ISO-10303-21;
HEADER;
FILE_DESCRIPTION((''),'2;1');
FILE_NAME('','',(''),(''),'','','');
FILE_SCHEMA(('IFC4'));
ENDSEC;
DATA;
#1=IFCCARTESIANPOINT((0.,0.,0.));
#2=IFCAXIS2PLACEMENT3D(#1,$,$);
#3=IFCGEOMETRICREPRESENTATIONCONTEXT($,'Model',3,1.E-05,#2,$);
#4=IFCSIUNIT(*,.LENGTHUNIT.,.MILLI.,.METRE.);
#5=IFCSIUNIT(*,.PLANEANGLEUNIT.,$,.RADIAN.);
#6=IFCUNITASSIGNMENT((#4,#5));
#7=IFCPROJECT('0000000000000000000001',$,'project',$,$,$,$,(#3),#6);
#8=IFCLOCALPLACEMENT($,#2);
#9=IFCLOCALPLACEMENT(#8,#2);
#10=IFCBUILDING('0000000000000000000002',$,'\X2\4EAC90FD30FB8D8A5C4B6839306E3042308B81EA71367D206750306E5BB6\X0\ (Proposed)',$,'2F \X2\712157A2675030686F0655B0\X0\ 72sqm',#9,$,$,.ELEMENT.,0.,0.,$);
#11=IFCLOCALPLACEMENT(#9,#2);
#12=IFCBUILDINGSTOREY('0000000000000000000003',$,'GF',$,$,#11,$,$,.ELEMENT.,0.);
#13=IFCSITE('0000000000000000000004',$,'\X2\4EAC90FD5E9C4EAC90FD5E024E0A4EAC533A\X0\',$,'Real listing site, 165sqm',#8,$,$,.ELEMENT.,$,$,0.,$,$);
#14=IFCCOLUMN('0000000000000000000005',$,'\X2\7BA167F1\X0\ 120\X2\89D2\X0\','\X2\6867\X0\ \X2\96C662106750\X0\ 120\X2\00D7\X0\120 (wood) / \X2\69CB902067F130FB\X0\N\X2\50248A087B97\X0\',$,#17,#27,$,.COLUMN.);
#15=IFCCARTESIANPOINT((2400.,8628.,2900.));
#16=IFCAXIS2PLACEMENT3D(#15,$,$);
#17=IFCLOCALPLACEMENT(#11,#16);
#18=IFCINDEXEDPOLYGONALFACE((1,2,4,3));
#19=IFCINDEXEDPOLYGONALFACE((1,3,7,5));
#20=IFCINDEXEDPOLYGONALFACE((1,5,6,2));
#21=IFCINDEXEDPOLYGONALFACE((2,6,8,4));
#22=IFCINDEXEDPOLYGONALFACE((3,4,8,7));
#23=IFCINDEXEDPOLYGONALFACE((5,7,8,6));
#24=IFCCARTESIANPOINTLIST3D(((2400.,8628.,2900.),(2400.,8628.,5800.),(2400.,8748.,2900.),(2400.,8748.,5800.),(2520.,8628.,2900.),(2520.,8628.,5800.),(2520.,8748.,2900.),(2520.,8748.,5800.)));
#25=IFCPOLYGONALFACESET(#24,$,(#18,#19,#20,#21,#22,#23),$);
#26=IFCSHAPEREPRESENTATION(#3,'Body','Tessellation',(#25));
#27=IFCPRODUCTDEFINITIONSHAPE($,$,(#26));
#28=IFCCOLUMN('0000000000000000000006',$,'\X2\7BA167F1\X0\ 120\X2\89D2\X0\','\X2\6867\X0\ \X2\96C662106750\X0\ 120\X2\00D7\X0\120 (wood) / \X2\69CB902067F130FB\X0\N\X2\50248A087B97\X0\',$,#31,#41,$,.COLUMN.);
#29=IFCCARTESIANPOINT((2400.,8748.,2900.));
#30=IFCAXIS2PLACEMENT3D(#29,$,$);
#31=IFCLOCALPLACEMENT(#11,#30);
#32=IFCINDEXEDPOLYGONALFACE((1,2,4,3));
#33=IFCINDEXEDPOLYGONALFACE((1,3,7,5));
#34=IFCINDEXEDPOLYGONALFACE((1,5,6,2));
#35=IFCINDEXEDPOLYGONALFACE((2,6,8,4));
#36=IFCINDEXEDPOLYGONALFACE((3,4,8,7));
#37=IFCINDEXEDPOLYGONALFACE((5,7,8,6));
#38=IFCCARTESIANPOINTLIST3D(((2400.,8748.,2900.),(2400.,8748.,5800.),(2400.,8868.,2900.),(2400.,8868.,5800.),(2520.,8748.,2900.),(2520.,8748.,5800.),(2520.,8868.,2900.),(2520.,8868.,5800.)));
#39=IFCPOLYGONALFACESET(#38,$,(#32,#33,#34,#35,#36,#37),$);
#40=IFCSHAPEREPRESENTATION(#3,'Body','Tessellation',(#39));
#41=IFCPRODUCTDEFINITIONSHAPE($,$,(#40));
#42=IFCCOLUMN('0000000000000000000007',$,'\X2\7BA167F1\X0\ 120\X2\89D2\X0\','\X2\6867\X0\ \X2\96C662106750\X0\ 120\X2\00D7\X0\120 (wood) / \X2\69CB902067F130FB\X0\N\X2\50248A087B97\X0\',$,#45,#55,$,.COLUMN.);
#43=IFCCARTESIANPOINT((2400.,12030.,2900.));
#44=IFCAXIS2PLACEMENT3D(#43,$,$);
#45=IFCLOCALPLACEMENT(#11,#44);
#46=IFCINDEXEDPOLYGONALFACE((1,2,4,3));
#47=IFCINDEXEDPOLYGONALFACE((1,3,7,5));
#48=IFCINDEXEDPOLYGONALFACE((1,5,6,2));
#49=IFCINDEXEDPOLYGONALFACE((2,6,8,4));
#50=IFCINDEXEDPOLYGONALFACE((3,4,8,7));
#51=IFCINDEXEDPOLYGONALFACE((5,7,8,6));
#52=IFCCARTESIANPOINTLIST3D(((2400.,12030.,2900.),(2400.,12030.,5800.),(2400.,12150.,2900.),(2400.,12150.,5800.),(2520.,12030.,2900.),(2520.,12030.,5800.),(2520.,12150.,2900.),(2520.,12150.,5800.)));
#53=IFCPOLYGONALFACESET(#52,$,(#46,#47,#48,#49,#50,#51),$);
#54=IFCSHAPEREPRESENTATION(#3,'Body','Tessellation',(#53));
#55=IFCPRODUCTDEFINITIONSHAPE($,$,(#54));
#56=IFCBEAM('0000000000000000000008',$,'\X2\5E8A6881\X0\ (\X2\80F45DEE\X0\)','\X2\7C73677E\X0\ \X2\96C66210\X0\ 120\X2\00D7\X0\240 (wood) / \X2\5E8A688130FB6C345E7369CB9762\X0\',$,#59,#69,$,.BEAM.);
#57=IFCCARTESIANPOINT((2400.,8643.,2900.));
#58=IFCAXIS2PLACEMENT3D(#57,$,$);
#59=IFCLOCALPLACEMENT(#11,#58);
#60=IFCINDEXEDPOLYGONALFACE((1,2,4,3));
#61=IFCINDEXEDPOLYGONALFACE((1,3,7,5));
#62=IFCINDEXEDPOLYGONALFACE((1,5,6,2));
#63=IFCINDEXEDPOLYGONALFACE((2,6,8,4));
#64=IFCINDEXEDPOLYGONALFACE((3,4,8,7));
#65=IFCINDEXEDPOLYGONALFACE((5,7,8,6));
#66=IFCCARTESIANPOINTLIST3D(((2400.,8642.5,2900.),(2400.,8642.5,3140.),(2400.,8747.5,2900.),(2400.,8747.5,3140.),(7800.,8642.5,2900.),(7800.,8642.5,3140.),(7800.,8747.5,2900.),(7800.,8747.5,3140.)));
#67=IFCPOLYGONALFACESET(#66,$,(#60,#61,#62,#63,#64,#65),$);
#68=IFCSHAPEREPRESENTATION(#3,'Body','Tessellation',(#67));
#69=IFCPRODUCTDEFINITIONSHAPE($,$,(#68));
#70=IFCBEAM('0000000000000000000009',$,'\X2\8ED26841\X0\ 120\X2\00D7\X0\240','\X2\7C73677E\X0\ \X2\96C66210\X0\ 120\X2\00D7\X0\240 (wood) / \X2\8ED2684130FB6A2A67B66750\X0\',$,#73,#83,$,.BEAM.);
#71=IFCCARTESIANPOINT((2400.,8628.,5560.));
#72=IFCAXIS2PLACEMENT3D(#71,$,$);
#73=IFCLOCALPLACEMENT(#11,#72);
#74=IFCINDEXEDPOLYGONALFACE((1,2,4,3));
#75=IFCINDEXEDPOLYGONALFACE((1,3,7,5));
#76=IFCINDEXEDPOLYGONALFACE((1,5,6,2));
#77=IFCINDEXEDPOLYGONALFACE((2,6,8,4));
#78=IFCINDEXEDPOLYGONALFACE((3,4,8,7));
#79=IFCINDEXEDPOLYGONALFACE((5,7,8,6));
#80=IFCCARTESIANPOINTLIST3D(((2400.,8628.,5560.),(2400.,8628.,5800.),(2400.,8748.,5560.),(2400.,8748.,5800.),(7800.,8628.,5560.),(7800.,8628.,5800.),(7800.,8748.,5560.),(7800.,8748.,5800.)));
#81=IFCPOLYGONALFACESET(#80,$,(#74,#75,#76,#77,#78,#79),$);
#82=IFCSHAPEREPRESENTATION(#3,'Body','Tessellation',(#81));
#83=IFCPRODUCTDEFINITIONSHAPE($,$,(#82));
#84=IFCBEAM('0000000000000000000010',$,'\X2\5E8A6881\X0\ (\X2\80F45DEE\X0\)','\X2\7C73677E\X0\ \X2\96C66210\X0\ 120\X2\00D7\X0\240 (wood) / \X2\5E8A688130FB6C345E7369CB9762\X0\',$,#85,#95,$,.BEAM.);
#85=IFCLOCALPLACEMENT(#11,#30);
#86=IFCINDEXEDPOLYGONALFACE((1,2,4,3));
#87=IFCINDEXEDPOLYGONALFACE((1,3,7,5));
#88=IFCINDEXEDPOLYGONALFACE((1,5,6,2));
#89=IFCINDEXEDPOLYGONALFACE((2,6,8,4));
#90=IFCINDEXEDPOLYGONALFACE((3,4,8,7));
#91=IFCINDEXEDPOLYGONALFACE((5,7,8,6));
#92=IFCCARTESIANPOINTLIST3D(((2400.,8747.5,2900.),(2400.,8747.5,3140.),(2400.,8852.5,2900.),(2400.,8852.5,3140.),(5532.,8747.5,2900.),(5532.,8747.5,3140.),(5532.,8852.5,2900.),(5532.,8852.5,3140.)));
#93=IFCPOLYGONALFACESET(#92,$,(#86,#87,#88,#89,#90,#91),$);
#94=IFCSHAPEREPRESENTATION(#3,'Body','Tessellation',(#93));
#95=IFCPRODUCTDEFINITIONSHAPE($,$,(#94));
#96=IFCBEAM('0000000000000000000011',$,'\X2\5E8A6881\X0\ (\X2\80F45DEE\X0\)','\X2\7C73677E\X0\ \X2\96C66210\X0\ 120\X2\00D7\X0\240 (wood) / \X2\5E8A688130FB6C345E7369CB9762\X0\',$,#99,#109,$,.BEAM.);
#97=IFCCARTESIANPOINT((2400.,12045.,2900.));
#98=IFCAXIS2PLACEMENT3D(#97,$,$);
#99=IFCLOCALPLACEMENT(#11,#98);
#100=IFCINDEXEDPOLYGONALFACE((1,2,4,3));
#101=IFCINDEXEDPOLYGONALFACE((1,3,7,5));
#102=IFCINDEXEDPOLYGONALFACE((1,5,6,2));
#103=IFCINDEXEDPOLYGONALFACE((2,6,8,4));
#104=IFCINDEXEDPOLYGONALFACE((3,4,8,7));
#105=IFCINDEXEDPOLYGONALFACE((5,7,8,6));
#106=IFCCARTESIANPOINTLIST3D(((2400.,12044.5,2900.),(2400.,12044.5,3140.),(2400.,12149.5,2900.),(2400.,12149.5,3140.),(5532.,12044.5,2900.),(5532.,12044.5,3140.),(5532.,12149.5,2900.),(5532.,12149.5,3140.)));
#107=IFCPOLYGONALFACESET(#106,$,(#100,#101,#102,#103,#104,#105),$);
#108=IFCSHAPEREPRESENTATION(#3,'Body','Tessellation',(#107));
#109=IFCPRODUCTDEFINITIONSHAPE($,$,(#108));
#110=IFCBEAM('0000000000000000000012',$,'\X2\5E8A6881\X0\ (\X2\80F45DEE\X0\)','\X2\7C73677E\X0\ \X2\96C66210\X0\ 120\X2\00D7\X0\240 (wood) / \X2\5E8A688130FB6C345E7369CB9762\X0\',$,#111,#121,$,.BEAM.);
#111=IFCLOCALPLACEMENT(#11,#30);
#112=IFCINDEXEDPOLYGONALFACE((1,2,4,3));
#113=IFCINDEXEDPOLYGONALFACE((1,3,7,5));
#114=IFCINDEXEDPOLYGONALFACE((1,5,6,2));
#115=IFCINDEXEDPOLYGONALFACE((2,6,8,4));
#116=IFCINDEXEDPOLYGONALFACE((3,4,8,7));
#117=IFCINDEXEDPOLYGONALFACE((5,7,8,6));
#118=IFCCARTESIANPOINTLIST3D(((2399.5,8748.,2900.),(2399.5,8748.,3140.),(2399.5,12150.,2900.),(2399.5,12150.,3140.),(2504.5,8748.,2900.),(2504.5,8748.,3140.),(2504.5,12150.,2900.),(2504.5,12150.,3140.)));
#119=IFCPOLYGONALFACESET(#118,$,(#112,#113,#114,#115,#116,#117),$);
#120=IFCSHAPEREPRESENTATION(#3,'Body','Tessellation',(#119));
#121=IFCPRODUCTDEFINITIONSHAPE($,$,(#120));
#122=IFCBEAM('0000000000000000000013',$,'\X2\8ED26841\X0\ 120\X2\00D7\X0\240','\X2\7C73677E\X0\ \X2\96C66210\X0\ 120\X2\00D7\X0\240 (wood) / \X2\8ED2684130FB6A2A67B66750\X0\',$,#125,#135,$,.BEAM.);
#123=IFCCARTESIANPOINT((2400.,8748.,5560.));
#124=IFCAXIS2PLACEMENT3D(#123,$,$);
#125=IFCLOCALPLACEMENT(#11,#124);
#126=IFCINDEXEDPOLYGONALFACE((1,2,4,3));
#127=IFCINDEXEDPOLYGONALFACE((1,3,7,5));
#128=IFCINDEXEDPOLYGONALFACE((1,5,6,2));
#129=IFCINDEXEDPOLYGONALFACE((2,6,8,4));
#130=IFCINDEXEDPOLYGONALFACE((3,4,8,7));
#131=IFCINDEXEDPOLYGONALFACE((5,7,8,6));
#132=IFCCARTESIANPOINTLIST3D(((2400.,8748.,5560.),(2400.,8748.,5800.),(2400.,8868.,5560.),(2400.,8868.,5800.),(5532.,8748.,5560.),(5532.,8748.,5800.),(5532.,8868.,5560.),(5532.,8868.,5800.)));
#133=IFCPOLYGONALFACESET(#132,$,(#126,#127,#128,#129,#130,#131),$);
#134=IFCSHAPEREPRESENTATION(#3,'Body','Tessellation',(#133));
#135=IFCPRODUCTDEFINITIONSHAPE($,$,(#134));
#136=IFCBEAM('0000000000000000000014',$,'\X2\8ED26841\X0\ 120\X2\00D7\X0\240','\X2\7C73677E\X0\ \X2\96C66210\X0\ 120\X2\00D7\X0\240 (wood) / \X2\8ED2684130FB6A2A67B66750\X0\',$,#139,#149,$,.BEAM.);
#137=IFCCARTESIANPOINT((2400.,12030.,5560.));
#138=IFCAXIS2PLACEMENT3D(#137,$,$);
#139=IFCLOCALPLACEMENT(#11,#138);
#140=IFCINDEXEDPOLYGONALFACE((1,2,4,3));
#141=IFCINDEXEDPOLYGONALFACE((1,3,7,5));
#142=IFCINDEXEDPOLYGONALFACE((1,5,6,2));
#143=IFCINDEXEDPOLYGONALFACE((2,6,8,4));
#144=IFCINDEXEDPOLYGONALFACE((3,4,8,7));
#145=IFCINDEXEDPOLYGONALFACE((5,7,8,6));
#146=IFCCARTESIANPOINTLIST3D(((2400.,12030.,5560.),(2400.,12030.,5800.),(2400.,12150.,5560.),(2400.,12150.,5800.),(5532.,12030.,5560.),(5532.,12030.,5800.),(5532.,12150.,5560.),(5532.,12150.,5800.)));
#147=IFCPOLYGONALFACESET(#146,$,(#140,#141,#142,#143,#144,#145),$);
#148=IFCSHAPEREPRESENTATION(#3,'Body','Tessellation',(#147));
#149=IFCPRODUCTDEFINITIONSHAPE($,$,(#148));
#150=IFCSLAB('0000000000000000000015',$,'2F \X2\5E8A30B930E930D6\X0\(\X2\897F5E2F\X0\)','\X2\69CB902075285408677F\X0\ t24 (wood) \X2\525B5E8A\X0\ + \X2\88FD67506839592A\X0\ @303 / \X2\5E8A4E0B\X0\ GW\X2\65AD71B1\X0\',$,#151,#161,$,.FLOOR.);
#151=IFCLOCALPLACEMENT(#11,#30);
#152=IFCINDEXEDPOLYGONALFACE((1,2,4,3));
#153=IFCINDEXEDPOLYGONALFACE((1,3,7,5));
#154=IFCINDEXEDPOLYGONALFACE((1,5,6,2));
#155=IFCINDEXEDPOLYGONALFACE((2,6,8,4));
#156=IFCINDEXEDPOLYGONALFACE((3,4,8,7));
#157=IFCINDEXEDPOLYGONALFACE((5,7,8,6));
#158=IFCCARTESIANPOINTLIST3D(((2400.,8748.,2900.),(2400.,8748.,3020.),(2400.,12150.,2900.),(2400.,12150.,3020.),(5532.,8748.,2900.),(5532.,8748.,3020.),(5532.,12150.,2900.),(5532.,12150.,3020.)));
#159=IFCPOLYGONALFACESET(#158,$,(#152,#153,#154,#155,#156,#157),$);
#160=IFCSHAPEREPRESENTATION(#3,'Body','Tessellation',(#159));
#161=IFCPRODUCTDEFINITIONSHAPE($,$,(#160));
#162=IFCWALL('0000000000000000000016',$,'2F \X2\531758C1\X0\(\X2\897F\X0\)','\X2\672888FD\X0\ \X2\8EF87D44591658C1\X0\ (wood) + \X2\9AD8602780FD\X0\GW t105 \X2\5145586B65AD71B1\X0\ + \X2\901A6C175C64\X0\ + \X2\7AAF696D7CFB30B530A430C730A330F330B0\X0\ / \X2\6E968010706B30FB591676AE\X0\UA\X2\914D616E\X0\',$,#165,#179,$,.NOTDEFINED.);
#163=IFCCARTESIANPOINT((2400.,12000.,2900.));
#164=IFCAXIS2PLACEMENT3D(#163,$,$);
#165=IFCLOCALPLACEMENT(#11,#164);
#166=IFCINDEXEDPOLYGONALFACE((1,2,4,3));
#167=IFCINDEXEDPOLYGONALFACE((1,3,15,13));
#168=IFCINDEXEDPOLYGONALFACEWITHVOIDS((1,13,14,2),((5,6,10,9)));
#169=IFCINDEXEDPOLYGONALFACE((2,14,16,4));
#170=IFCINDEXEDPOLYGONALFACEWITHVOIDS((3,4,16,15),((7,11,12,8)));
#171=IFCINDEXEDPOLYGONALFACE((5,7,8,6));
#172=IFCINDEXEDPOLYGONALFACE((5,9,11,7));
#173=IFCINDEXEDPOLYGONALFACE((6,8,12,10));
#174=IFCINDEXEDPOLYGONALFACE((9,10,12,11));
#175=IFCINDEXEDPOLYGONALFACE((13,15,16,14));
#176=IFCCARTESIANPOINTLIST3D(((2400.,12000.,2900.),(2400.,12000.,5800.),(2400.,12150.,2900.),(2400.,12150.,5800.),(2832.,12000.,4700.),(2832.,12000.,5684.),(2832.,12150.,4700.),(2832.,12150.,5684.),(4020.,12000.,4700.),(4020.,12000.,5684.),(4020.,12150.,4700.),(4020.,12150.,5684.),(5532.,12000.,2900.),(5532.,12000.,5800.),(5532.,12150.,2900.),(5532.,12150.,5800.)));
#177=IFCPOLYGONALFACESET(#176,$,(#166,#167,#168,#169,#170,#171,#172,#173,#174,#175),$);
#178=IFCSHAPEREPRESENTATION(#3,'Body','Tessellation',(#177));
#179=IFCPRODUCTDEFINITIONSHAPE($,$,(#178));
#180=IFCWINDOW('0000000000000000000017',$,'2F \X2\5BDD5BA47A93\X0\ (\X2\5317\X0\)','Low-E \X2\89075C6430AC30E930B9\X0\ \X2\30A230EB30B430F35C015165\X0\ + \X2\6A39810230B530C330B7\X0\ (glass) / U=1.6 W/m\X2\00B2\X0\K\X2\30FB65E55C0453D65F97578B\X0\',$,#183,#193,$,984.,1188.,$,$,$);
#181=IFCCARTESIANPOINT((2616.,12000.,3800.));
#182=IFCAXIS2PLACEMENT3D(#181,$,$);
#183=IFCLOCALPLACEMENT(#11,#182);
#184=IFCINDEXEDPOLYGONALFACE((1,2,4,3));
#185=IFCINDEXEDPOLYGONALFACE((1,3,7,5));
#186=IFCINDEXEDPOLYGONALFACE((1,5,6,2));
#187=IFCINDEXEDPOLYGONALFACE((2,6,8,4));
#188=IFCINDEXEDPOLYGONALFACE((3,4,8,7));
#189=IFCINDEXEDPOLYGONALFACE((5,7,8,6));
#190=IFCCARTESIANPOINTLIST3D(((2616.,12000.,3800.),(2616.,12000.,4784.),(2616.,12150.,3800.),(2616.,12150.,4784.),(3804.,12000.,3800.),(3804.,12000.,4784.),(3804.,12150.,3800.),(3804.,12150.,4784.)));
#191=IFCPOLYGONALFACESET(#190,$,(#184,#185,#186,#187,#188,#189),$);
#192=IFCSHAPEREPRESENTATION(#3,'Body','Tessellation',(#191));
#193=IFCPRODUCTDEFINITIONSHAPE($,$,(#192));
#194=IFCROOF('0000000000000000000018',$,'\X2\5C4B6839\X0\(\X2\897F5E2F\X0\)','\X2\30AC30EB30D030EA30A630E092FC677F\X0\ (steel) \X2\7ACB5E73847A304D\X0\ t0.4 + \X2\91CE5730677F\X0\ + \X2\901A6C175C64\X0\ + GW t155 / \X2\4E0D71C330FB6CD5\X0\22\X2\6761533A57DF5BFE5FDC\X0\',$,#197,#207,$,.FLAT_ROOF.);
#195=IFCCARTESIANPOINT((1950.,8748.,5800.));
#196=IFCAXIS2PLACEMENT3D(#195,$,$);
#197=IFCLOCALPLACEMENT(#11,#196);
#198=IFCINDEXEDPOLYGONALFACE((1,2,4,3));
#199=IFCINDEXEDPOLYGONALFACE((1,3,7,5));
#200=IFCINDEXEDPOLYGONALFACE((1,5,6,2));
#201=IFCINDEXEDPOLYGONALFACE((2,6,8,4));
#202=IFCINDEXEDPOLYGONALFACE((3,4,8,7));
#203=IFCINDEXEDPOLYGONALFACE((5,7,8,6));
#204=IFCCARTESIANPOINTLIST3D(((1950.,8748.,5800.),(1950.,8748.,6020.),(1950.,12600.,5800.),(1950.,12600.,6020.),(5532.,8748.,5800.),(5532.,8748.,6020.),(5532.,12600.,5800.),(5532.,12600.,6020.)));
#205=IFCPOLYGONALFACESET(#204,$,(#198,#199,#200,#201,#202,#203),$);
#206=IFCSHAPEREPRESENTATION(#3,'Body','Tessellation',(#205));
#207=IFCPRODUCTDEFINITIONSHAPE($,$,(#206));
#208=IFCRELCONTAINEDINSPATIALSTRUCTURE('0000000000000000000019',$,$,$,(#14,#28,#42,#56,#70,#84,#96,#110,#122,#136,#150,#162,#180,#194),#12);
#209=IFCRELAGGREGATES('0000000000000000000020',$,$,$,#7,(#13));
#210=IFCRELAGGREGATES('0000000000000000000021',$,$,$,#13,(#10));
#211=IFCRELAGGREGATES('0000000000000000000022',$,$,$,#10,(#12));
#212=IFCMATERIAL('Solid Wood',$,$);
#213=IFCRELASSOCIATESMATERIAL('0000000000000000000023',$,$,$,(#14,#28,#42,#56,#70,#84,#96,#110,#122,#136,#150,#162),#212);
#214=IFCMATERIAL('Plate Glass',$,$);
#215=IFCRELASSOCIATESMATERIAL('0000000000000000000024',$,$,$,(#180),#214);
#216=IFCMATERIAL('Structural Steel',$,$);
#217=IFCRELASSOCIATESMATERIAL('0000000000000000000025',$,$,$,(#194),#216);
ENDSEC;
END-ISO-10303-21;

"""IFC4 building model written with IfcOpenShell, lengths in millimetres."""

from ifc_helpers import new_model, si_unit, frame, frame_2d, origin, place, context, project, spatial, rectangle, extrude, material, element, fill, save


model = new_model("IFC4")

# Units and contexts
model_context = context("Model", 3, precision=1e-05, world=origin())
ifc_project = project(units=[si_unit("LENGTHUNIT", "METRE", prefix="MILLI"), si_unit("PLANEANGLEUNIT", "RADIAN")], contexts=[model_context])

# Site, building, storey
site_placement = place(None, origin())
site = spatial("IfcSite", under=ifc_project, at=site_placement, Name="京都府京都市上京区", ObjectType="Real listing site, 165sqm", CompositionType="ELEMENT", RefElevation=0.0)
building_placement = place(site_placement, origin())
building = spatial("IfcBuilding", under=site, at=building_placement, Name="京都・越屋根のある自然素材の家 (Proposed)", ObjectType="2F 無垢材と漆喰 72sqm", CompositionType="ELEMENT", ElevationOfRefHeight=0.0, ElevationOfTerrain=0.0)
storey_placement = place(building_placement, origin())
storey = spatial("IfcBuildingStorey", under=building, at=storey_placement, Name="GF", CompositionType="ELEMENT", Elevation=0.0)

# Columns
ifc_material_1 = material(Name="Solid Wood")
column_1_placement = place(storey_placement, frame((2400.0, 8628.0, 2900.0)))
element("IfcColumn", 1, at=column_1_placement, inside=storey, material=ifc_material_1, Name="管柱 120角", Description="桧 集成材 120×120 (wood) / 構造柱・N値計算", PredefinedType="COLUMN", context=model_context, shape_type="SweptSolid", body=[
    extrude(rectangle(XDim=120.0, YDim=120.0, at=frame_2d((60.0, 60.0))), frame((2400.0, 8628.0, 2900.0)), (0.0, 0.0, 1.0), 2900.0),
])
column_2_placement = place(storey_placement, frame((2400.0, 8748.0, 2900.0)))
element("IfcColumn", 2, at=column_2_placement, inside=storey, material=ifc_material_1, Name="管柱 120角", Description="桧 集成材 120×120 (wood) / 構造柱・N値計算", PredefinedType="COLUMN", context=model_context, shape_type="SweptSolid", body=[
    extrude(rectangle(XDim=120.0, YDim=120.0, at=frame_2d((60.0, 60.0))), frame((2400.0, 8748.0, 2900.0)), (0.0, 0.0, 1.0), 2900.0),
])
column_3_placement = place(storey_placement, frame((2400.0, 12030.0, 2900.0)))
element("IfcColumn", 3, at=column_3_placement, inside=storey, material=ifc_material_1, Name="管柱 120角", Description="桧 集成材 120×120 (wood) / 構造柱・N値計算", PredefinedType="COLUMN", context=model_context, shape_type="SweptSolid", body=[
    extrude(rectangle(XDim=120.0, YDim=120.0, at=frame_2d((60.0, 60.0))), frame((2400.0, 12030.0, 2900.0)), (0.0, 0.0, 1.0), 2900.0),
])

# Beams
beam_1_placement = place(storey_placement, frame((2400.0, 8643.0, 2900.0)))
element("IfcBeam", 4, at=beam_1_placement, inside=storey, material=ifc_material_1, Name="床梁 (胴差)", Description="米松 集成 120×240 (wood) / 床梁・水平構面", PredefinedType="BEAM", context=model_context, shape_type="SweptSolid", body=[
    extrude(rectangle(XDim=5400.0, YDim=105.0, at=frame_2d((2700.0, 52.0))), frame((2400.0, 8643.0, 2900.0)), (0.0, 0.0, 1.0), 240.0),
])
beam_2_placement = place(storey_placement, frame((2400.0, 8628.0, 5560.0)))
element("IfcBeam", 5, at=beam_2_placement, inside=storey, material=ifc_material_1, Name="軒桁 120×240", Description="米松 集成 120×240 (wood) / 軒桁・横架材", PredefinedType="BEAM", context=model_context, shape_type="SweptSolid", body=[
    extrude(rectangle(XDim=5400.0, YDim=120.0, at=frame_2d((2700.0, 60.0))), frame((2400.0, 8628.0, 5560.0)), (0.0, 0.0, 1.0), 240.0),
])
beam_3_placement = place(storey_placement, frame((2400.0, 8748.0, 2900.0)))
element("IfcBeam", 6, at=beam_3_placement, inside=storey, material=ifc_material_1, Name="床梁 (胴差)", Description="米松 集成 120×240 (wood) / 床梁・水平構面", PredefinedType="BEAM", context=model_context, shape_type="SweptSolid", body=[
    extrude(rectangle(XDim=3132.0, YDim=105.0, at=frame_2d((1566.0, 52.0))), frame((2400.0, 8748.0, 2900.0)), (0.0, 0.0, 1.0), 240.0),
])
beam_4_placement = place(storey_placement, frame((2400.0, 12045.0, 2900.0)))
element("IfcBeam", 7, at=beam_4_placement, inside=storey, material=ifc_material_1, Name="床梁 (胴差)", Description="米松 集成 120×240 (wood) / 床梁・水平構面", PredefinedType="BEAM", context=model_context, shape_type="SweptSolid", body=[
    extrude(rectangle(XDim=3132.0, YDim=105.0, at=frame_2d((1566.0, 52.0))), frame((2400.0, 12045.0, 2900.0)), (0.0, 0.0, 1.0), 240.0),
])
beam_5_placement = place(storey_placement, frame((2400.0, 8748.0, 2900.0)))
element("IfcBeam", 8, at=beam_5_placement, inside=storey, material=ifc_material_1, Name="床梁 (胴差)", Description="米松 集成 120×240 (wood) / 床梁・水平構面", PredefinedType="BEAM", context=model_context, shape_type="SweptSolid", body=[
    extrude(rectangle(XDim=105.0, YDim=3402.0, at=frame_2d((52.0, 1701.0))), frame((2400.0, 8748.0, 2900.0)), (0.0, 0.0, 1.0), 240.0),
])
beam_6_placement = place(storey_placement, frame((2400.0, 8748.0, 5560.0)))
element("IfcBeam", 9, at=beam_6_placement, inside=storey, material=ifc_material_1, Name="軒桁 120×240", Description="米松 集成 120×240 (wood) / 軒桁・横架材", PredefinedType="BEAM", context=model_context, shape_type="SweptSolid", body=[
    extrude(rectangle(XDim=3132.0, YDim=120.0, at=frame_2d((1566.0, 60.0))), frame((2400.0, 8748.0, 5560.0)), (0.0, 0.0, 1.0), 240.0),
])
beam_7_placement = place(storey_placement, frame((2400.0, 12030.0, 5560.0)))
element("IfcBeam", 10, at=beam_7_placement, inside=storey, material=ifc_material_1, Name="軒桁 120×240", Description="米松 集成 120×240 (wood) / 軒桁・横架材", PredefinedType="BEAM", context=model_context, shape_type="SweptSolid", body=[
    extrude(rectangle(XDim=3132.0, YDim=120.0, at=frame_2d((1566.0, 60.0))), frame((2400.0, 12030.0, 5560.0)), (0.0, 0.0, 1.0), 240.0),
])

# Slab
slab_placement = place(storey_placement, frame((2400.0, 8748.0, 2900.0)))
element("IfcSlab", 11, at=slab_placement, inside=storey, material=ifc_material_1, Name="2F 床スラブ(西帯)", Description="構造用合板 t24 (wood) 剛床 + 製材根太 @303 / 床下 GW断熱", PredefinedType="FLOOR", context=model_context, shape_type="SweptSolid", body=[
    extrude(rectangle(XDim=3132.0, YDim=3402.0, at=frame_2d((1566.0, 1701.0))), frame((2400.0, 8748.0, 2900.0)), (0.0, 0.0, 1.0), 120.0),
])

# Wall, opening, window
wall_1_placement = place(storey_placement, frame((2400.0, 12000.0, 2900.0)))
wall_1 = element("IfcWall", 12, at=wall_1_placement, inside=storey, material=ifc_material_1, Name="2F 北壁(西)", Description="木製 軸組外壁 (wood) + 高性能GW t105 充填断熱 + 通気層 + 窯業系サイディング / 準耐火・外皮UA配慮", PredefinedType="NOTDEFINED", context=model_context, shape_type="SweptSolid", body=[
    extrude(rectangle(XDim=3132.0, YDim=150.0, at=frame_2d((1566.0, 75.0))), frame((2400.0, 12000.0, 2900.0)), (0.0, 0.0, 1.0), 2900.0),
])
opening_placement = place(storey_placement, frame((2616.0, 12000.0, 3800.0)))
opening = element("IfcOpeningElement", 13, at=opening_placement, cuts=wall_1, PredefinedType="NOTDEFINED", context=model_context, shape_type="SweptSolid", body=[
    extrude(rectangle(XDim=1188.0, YDim=150.0, at=frame_2d((594.0, 75.0))), frame((2616.0, 12000.0, 3800.0)), (0.0, 0.0, 1.0), 984.0),
])
ifc_material_2 = material(Name="Plate Glass")
window_placement = place(storey_placement, frame((2616.0, 12000.0, 3800.0)))
window = element("IfcWindow", 14, at=window_placement, inside=storey, material=ifc_material_2, Name="2F 寝室窓 (北)", Description="Low-E 複層ガラス アルゴン封入 + 樹脂サッシ (glass) / U=1.6 W/m²K・日射取得型", OverallHeight=984.0, OverallWidth=1188.0, context=model_context, shape_type="SweptSolid", body=[
    extrude(rectangle(XDim=1188.0, YDim=150.0, at=frame_2d((594.0, 75.0))), frame((2616.0, 12000.0, 3800.0)), (0.0, 0.0, 1.0), 984.0),
])
fill(opening, window)

# Roof
ifc_material_3 = material(Name="Structural Steel")
for number, where, name in (
    (15, (1950.0, 8748.0, 5800.0), "屋根(西帯)"),
):
    element("IfcRoof", number, at=place(storey_placement, frame(where)), inside=storey, material=ifc_material_3, Name=name, Description="ガルバリウム鋼板 (steel) 立平葺き t0.4 + 野地板 + 通気層 + GW t155 / 不燃・法22条区域対応", PredefinedType="FLAT_ROOF", context=model_context, shape_type="SweptSolid", body=[
        extrude(rectangle(XDim=3582.0, YDim=3852.0, at=frame_2d((1791.0, 1926.0))), frame((1950.0, 8748.0, 5800.0)), (0.0, 0.0, 1.0), 220.0),
    ])

save(model, "model.ifc")
